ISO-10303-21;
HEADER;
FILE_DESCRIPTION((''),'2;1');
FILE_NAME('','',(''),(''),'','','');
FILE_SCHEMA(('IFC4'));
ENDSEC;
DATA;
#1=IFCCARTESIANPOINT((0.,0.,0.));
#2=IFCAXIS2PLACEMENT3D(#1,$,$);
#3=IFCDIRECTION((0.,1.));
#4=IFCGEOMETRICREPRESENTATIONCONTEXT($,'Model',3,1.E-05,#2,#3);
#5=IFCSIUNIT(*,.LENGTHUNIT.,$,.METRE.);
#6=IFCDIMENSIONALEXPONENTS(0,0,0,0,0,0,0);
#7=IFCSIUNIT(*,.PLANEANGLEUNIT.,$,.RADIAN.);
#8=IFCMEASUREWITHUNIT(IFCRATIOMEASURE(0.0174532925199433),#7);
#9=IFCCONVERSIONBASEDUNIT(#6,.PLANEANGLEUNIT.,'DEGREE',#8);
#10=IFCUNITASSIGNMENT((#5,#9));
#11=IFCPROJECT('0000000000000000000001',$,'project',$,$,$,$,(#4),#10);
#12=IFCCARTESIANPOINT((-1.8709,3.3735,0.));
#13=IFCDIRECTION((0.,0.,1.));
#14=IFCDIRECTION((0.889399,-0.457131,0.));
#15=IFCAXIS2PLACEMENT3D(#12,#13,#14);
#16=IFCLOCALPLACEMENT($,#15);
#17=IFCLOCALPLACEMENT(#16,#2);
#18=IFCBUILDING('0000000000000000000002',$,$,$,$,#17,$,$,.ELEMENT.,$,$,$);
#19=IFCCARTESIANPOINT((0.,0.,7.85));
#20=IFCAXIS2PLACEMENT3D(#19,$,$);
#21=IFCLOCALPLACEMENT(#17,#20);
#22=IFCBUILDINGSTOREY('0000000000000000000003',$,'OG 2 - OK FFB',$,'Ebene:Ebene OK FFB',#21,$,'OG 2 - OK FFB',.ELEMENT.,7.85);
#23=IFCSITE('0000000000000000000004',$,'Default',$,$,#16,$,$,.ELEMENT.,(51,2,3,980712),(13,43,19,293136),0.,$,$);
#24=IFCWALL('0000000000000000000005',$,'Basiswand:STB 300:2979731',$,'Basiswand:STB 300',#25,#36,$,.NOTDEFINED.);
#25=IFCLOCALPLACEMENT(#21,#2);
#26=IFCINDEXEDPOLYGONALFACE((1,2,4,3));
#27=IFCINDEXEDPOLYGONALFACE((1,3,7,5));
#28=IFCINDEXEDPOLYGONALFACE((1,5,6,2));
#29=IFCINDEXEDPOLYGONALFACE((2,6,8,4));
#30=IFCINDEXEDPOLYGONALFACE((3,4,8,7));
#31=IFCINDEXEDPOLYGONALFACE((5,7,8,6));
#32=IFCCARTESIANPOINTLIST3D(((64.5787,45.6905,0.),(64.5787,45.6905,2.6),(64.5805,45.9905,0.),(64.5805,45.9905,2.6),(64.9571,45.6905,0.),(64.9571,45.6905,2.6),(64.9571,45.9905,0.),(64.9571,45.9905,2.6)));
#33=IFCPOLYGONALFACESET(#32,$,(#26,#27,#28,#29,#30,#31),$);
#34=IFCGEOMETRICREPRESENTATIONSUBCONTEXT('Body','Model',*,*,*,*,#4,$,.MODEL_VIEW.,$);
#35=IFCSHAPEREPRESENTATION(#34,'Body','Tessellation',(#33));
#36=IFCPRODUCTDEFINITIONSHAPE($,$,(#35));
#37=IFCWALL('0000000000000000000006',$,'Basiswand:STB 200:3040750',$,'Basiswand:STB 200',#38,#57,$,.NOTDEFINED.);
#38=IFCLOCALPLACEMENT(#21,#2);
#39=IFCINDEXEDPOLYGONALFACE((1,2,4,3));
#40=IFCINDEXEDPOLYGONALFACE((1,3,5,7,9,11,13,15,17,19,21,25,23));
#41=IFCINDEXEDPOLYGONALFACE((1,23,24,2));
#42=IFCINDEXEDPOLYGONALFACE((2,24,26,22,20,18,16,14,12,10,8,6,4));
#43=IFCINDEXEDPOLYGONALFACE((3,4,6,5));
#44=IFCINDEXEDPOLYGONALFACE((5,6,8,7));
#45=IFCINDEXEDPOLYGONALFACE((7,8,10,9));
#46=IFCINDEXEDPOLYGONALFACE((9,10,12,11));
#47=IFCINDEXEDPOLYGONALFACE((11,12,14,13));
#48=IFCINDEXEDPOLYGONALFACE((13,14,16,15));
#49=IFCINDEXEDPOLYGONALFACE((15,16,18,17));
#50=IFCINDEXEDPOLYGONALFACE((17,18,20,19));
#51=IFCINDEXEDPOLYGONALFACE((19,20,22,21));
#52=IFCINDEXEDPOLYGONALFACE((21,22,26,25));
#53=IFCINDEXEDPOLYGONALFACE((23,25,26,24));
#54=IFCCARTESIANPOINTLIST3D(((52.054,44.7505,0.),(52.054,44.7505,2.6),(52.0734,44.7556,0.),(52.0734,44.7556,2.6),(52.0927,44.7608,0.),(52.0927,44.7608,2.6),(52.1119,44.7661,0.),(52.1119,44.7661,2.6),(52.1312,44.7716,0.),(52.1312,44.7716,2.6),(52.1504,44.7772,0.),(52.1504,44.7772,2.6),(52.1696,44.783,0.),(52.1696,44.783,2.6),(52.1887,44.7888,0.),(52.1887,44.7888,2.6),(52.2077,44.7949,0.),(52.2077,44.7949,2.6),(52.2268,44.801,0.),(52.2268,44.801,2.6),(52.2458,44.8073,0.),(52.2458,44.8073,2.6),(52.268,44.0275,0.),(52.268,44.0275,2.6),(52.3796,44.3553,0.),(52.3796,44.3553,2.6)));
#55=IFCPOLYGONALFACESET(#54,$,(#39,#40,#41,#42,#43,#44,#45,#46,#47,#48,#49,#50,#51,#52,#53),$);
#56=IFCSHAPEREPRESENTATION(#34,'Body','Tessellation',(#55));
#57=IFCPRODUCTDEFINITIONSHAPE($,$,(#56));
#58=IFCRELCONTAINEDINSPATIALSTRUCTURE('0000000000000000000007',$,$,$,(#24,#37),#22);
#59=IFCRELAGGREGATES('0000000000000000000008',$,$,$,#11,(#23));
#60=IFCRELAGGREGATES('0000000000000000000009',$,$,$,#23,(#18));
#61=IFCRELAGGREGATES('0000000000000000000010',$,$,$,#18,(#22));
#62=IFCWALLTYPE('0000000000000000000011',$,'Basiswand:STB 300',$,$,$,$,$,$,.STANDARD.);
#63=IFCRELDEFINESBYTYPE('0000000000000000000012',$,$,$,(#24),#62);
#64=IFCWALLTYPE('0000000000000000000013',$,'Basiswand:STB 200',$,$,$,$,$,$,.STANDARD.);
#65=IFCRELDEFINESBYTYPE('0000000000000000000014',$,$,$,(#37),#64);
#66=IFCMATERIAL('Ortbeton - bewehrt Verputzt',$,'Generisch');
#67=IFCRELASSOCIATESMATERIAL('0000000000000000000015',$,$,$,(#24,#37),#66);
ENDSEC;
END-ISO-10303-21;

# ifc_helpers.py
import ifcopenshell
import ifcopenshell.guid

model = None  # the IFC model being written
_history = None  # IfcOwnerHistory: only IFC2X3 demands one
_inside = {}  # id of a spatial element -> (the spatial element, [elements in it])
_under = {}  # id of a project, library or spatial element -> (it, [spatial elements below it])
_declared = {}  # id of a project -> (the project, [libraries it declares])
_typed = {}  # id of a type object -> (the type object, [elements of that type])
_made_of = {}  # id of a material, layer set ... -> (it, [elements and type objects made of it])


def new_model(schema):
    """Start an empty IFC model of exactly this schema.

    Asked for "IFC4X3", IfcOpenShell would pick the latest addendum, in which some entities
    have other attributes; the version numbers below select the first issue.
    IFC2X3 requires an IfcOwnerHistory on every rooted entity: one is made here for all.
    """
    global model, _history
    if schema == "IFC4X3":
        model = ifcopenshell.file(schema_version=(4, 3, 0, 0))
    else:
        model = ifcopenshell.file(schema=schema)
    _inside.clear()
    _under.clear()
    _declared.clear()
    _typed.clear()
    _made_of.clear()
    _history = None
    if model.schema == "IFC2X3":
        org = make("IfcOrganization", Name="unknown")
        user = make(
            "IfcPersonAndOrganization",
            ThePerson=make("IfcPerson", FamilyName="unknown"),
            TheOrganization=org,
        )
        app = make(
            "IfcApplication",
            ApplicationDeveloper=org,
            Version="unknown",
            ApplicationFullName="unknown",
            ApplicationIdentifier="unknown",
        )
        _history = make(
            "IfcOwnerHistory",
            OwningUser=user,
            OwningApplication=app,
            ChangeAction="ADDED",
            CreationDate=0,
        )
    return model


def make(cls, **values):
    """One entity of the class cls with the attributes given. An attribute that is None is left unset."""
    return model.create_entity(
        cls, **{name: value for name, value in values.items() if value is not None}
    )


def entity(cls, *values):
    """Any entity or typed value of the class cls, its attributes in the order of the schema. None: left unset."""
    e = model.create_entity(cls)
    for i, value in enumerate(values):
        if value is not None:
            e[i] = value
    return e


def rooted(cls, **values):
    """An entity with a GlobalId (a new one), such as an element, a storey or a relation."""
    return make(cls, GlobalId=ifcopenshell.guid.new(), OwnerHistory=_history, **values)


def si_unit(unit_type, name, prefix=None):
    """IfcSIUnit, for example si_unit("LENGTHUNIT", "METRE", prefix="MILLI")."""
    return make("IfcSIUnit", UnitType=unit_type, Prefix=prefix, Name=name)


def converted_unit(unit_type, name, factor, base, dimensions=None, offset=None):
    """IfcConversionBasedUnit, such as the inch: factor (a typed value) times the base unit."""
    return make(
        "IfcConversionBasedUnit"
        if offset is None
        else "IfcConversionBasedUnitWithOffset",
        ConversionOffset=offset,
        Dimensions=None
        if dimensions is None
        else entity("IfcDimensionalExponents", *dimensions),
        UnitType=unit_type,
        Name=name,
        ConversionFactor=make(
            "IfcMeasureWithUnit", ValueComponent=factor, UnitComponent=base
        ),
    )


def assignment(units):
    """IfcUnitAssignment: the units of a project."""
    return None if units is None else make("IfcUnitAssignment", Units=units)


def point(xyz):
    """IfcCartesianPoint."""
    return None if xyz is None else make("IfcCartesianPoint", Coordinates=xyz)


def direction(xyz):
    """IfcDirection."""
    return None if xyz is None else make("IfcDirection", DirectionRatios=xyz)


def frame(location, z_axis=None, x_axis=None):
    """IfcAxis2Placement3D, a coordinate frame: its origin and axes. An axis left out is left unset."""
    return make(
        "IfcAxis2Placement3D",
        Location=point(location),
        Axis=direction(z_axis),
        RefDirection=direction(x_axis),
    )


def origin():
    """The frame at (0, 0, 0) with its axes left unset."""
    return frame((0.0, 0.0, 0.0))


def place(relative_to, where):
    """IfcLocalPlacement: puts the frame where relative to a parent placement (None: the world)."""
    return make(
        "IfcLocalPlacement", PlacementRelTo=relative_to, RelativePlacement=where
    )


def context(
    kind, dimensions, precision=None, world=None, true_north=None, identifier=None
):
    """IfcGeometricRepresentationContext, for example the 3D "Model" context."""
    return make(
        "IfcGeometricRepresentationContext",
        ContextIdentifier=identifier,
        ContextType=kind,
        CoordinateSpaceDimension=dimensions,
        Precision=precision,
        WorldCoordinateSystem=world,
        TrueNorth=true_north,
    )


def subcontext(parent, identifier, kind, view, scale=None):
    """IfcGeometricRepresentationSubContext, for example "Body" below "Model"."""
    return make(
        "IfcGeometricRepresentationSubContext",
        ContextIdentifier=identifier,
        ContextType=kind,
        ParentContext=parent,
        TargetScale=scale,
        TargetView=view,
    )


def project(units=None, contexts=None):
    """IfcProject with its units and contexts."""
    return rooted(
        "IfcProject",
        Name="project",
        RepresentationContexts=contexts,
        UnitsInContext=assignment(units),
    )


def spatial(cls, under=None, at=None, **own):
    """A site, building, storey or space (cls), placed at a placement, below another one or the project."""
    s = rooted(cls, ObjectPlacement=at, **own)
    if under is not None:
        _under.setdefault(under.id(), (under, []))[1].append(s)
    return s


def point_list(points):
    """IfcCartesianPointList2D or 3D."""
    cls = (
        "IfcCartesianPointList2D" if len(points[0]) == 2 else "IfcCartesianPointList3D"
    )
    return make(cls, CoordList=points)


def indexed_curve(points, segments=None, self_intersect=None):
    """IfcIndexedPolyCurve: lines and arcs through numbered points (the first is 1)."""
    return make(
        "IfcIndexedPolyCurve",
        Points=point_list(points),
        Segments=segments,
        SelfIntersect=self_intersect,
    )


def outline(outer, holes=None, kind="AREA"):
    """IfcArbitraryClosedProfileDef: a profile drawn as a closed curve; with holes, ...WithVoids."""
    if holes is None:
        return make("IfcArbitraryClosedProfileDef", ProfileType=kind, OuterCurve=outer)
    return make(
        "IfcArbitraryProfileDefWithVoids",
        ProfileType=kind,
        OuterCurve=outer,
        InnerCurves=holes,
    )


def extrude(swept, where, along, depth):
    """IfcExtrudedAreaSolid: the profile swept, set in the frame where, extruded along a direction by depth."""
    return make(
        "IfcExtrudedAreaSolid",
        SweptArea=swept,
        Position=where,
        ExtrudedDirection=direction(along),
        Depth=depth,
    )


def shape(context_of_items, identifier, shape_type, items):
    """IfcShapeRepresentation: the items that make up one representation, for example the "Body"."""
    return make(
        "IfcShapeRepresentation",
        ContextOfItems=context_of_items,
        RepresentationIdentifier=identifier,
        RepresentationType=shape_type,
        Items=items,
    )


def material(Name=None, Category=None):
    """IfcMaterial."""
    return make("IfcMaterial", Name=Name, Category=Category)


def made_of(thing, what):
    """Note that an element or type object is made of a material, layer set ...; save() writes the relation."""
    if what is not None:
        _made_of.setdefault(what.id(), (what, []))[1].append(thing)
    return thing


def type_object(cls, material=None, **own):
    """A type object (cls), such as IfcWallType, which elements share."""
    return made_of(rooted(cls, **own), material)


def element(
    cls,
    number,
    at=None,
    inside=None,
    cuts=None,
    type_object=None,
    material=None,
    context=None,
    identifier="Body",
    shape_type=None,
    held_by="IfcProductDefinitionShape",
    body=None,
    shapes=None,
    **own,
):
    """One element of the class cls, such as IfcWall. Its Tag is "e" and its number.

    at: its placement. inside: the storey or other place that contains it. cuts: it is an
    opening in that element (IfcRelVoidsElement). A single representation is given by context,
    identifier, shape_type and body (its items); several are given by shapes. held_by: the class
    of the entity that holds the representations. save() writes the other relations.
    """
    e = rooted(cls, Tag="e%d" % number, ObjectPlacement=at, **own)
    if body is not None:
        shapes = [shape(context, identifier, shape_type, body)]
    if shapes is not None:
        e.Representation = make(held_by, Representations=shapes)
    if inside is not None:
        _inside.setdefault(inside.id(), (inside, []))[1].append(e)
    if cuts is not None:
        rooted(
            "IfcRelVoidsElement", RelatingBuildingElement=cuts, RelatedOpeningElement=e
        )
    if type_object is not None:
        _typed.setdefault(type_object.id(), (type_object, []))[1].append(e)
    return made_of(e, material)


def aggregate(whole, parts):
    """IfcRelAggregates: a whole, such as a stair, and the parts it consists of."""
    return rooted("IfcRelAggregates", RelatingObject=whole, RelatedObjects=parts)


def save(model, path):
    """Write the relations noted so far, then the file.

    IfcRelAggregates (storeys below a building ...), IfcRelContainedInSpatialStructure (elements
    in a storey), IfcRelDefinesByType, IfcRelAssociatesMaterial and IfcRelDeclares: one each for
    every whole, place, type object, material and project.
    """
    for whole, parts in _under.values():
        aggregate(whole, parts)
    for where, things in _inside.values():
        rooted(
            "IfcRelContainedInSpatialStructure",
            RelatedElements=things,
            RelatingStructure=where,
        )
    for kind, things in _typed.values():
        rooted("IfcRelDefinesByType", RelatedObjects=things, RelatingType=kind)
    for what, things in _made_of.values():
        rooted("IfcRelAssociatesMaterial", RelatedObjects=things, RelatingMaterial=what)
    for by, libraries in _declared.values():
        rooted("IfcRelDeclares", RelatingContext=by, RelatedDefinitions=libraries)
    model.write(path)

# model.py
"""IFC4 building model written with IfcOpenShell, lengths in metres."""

from ifc_helpers import new_model, entity, si_unit, converted_unit, direction, frame, origin, place, context, subcontext, project, spatial, indexed_curve, outline, extrude, material, type_object, element, save


model = new_model("IFC4")

# Units and contexts
model_context = context("Model", 3, precision=1e-05, world=origin(), true_north=direction((0.0, 1.0)))
body_context = subcontext(model_context, "Body", "Model", "MODEL_VIEW")
ifc_project = project(units=[si_unit("LENGTHUNIT", "METRE"), converted_unit("PLANEANGLEUNIT", "DEGREE", entity("IfcRatioMeasure", 0.0174532925199433), si_unit("PLANEANGLEUNIT", "RADIAN"), dimensions=[0, 0, 0, 0, 0, 0, 0])], contexts=[model_context])

# Site, building, storey
site_placement = place(None, frame((-1.8709, 3.3735, 0.0), z_axis=(0.0, 0.0, 1.0), x_axis=(0.889399, -0.457131, 0.0)))
site = spatial("IfcSite", under=ifc_project, at=site_placement, Name="Default", CompositionType="ELEMENT", RefLatitude=(51, 2, 3, 980712), RefLongitude=(13, 43, 19, 293136), RefElevation=0.0)
building_placement = place(site_placement, origin())
building = spatial("IfcBuilding", under=site, at=building_placement, CompositionType="ELEMENT")
storey_placement = place(building_placement, frame((0.0, 0.0, 7.85)))
storey = spatial("IfcBuildingStorey", under=building, at=storey_placement, Name="OG 2 - OK FFB", ObjectType="Ebene:Ebene OK FFB", LongName="OG 2 - OK FFB", CompositionType="ELEMENT", Elevation=7.85)

# Walls
ifc_material_1 = material(Name="Ortbeton - bewehrt Verputzt", Category="Generisch")
wall_type_1 = type_object("IfcWallType", Name="Basiswand:STB 300", PredefinedType="STANDARD")
wall_1_placement = place(storey_placement, frame((64.5787, 45.8405, 0.0)))
element("IfcWall", 1, at=wall_1_placement, inside=storey, type_object=wall_type_1, material=ifc_material_1, Name="Basiswand:STB 300:2979731", ObjectType="Basiswand:STB 300", PredefinedType="NOTDEFINED", context=body_context, shape_type="SweptSolid", body=[
    extrude(outline(indexed_curve([(0.3784, -0.15), (0.3784, 0.15), (0.0018, 0.15), (0.0, -0.15), (0.3784, -0.15)], self_intersect=False)), origin(), (0.0, 0.0, 1.0), 2.6),
])
wall_type_2 = type_object("IfcWallType", Name="Basiswand:STB 200", PredefinedType="STANDARD")
wall_2_placement = place(storey_placement, frame((52.3639, 44.0559, 0.0), z_axis=(0.0, 0.0, 1.0), x_axis=(-0.283828, 0.958875, 0.0)))
element("IfcWall", 2, at=wall_2_placement, inside=storey, type_object=wall_type_2, material=ifc_material_1, Name="Basiswand:STB 200:3040750", ObjectType="Basiswand:STB 200", PredefinedType="NOTDEFINED", context=body_context, shape_type="SweptSolid", body=[
    extrude(outline(indexed_curve([(0.7541, -0.1), (0.7534, -0.08), (0.7529, -0.06), (0.7526, -0.04), (0.7524, -0.02), (0.7523, 0.0), (0.7524, 0.02), (0.7526, 0.04), (0.7529, 0.06), (0.7534, 0.08), (0.7541, 0.1), (0.0, 0.1), (0.2826, -0.1), (0.7541, -0.1)], self_intersect=False)), origin(), (0.0, 0.0, 1.0), 2.6),
])

save(model, "model.ifc")
